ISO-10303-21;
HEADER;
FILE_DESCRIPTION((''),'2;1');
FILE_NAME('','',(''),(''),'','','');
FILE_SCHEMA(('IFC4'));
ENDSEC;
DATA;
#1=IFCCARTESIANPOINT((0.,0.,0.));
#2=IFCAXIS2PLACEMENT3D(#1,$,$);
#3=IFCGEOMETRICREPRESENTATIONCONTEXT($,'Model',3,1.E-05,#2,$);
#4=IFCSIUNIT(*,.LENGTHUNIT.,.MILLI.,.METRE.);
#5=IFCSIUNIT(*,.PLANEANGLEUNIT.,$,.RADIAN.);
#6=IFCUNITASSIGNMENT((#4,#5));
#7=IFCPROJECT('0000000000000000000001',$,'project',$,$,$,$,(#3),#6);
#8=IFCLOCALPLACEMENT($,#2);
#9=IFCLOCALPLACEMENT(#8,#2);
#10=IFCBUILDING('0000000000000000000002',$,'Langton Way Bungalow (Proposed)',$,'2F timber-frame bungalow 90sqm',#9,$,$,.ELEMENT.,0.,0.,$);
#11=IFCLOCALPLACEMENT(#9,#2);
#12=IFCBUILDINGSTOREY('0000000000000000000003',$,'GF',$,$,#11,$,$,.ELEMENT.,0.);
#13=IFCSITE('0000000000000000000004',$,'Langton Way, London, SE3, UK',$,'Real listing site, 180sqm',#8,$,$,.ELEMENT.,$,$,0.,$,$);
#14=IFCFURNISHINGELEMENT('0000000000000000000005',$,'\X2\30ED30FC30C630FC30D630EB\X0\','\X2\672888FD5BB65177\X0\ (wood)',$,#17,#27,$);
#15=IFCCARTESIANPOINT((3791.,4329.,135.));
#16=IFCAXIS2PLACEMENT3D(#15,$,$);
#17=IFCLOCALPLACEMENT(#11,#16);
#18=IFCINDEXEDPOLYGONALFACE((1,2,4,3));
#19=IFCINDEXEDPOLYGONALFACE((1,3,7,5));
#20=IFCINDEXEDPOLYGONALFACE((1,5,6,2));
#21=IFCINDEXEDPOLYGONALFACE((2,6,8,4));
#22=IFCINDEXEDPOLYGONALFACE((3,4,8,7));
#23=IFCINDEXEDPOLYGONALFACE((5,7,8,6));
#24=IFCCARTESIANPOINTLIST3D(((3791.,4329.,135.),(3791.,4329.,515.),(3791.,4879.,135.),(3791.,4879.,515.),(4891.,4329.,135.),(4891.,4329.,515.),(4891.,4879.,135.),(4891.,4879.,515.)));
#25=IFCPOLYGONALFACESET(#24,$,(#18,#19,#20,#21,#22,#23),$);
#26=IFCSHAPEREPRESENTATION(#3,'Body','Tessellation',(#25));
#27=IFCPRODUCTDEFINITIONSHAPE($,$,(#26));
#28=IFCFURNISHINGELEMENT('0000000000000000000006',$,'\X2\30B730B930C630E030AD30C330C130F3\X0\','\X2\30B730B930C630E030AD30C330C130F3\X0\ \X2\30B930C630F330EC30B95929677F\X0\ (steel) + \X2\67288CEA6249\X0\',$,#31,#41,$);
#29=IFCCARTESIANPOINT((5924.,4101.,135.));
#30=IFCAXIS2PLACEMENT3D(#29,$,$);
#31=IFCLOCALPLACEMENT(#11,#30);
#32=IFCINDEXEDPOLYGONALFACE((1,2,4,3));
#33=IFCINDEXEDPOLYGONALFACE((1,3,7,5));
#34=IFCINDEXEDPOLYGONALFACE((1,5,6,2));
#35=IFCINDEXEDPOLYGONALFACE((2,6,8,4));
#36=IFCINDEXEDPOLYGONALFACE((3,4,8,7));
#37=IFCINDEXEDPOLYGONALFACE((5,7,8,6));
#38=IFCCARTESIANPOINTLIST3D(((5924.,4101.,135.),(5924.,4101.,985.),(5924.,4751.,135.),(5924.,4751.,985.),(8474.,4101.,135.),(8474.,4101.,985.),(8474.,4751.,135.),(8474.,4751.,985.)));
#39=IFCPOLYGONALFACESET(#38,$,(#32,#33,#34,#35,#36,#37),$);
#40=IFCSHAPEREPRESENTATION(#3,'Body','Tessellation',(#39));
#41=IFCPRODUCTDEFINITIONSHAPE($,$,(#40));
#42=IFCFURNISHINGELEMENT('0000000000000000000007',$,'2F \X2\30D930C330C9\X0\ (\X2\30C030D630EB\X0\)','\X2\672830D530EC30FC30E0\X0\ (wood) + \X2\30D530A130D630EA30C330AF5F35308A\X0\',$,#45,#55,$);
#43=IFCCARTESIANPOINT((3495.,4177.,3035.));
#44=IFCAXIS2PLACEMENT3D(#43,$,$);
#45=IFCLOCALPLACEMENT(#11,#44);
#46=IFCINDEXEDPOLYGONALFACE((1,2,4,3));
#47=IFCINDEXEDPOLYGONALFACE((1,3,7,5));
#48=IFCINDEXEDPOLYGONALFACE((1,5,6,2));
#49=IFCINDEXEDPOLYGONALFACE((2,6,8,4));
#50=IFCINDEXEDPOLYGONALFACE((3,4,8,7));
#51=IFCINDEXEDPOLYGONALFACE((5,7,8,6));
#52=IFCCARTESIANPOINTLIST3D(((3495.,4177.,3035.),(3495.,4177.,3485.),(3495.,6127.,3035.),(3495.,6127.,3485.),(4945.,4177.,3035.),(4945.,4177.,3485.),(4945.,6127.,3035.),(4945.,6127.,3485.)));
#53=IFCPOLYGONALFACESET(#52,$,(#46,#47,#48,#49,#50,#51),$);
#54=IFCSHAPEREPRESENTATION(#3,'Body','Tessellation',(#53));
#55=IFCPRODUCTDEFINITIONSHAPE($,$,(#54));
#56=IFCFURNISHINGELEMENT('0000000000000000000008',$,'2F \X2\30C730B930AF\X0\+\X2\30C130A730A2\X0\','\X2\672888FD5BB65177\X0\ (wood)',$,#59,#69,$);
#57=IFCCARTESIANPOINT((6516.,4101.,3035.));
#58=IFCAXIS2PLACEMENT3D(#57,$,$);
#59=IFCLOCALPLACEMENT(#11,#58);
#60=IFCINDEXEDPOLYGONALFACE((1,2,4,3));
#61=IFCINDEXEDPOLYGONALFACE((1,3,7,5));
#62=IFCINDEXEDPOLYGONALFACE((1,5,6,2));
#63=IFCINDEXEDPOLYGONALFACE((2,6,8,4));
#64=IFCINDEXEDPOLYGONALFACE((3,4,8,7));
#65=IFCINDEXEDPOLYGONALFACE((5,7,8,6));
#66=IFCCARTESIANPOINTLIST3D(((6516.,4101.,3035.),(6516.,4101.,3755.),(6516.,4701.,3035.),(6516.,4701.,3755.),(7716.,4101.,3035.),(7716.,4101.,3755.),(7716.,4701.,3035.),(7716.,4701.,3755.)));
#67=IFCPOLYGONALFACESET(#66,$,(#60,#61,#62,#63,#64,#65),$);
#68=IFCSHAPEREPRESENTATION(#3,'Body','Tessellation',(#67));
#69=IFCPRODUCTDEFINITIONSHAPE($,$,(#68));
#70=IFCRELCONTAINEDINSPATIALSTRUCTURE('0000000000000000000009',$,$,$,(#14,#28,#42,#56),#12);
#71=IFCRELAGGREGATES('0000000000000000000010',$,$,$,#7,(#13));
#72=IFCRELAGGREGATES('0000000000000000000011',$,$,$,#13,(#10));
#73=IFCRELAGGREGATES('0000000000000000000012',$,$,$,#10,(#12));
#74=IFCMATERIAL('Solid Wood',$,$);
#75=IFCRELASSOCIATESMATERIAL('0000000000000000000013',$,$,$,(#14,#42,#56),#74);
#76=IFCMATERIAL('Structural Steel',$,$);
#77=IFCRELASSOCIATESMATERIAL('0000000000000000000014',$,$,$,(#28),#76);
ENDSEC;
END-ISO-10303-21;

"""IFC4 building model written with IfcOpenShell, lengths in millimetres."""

from ifc_helpers import new_model, si_unit, frame, frame_2d, origin, place, context, project, spatial, rectangle, extrude, material, element, save


model = new_model("IFC4")

# Units and contexts
model_context = context("Model", 3, precision=1e-05, world=origin())
ifc_project = project(units=[si_unit("LENGTHUNIT", "METRE", prefix="MILLI"), si_unit("PLANEANGLEUNIT", "RADIAN")], contexts=[model_context])

# Site, building, storey
site_placement = place(None, origin())
site = spatial("IfcSite", under=ifc_project, at=site_placement, Name="Langton Way, London, SE3, UK", ObjectType="Real listing site, 180sqm", CompositionType="ELEMENT", RefElevation=0.0)
building_placement = place(site_placement, origin())
building = spatial("IfcBuilding", under=site, at=building_placement, Name="Langton Way Bungalow (Proposed)", ObjectType="2F timber-frame bungalow 90sqm", CompositionType="ELEMENT", ElevationOfRefHeight=0.0, ElevationOfTerrain=0.0)
storey_placement = place(building_placement, origin())
storey = spatial("IfcBuildingStorey", under=building, at=storey_placement, Name="GF", CompositionType="ELEMENT", Elevation=0.0)

# Shared definitions
ifc_material_1 = material(Name="Solid Wood")

# Shared definitions
ifc_material_2 = material(Name="Structural Steel")

# Furnishing elements
furnishing_1_placement = place(storey_placement, frame((3791.0, 4329.0, 135.0)))
element("IfcFurnishingElement", 1, at=furnishing_1_placement, inside=storey, material=ifc_material_1, Name="ローテーブル", Description="木製家具 (wood)", context=model_context, shape_type="SweptSolid", body=[
    extrude(rectangle(XDim=1100.0, YDim=550.0, at=frame_2d((550.0, 275.0))), frame((3791.0, 4329.0, 135.0)), (0.0, 0.0, 1.0), 380.0),
])
furnishing_2_placement = place(storey_placement, frame((5924.0, 4101.0, 135.0)))
element("IfcFurnishingElement", 2, at=furnishing_2_placement, inside=storey, material=ifc_material_2, Name="システムキッチン", Description="システムキッチン ステンレス天板 (steel) + 木質扉", context=model_context, shape_type="SweptSolid", body=[
    extrude(rectangle(XDim=2550.0, YDim=650.0, at=frame_2d((1275.0, 325.0))), frame((5924.0, 4101.0, 135.0)), (0.0, 0.0, 1.0), 850.0),
])
furnishing_3_placement = place(storey_placement, frame((3495.0, 4177.0, 3035.0)))
element("IfcFurnishingElement", 3, at=furnishing_3_placement, inside=storey, material=ifc_material_1, Name="2F ベッド (ダブル)", Description="木フレーム (wood) + ファブリック張り", context=model_context, shape_type="SweptSolid", body=[
    extrude(rectangle(XDim=1450.0, YDim=1950.0, at=frame_2d((725.0, 975.0))), frame((3495.0, 4177.0, 3035.0)), (0.0, 0.0, 1.0), 450.0),
])
furnishing_4_placement = place(storey_placement, frame((6516.0, 4101.0, 3035.0)))
element("IfcFurnishingElement", 4, at=furnishing_4_placement, inside=storey, material=ifc_material_1, Name="2F デスク+チェア", Description="木製家具 (wood)", context=model_context, shape_type="SweptSolid", body=[
    extrude(rectangle(XDim=1200.0, YDim=600.0, at=frame_2d((600.0, 300.0))), frame((6516.0, 4101.0, 3035.0)), (0.0, 0.0, 1.0), 720.0),
])

save(model, "model.ifc")
